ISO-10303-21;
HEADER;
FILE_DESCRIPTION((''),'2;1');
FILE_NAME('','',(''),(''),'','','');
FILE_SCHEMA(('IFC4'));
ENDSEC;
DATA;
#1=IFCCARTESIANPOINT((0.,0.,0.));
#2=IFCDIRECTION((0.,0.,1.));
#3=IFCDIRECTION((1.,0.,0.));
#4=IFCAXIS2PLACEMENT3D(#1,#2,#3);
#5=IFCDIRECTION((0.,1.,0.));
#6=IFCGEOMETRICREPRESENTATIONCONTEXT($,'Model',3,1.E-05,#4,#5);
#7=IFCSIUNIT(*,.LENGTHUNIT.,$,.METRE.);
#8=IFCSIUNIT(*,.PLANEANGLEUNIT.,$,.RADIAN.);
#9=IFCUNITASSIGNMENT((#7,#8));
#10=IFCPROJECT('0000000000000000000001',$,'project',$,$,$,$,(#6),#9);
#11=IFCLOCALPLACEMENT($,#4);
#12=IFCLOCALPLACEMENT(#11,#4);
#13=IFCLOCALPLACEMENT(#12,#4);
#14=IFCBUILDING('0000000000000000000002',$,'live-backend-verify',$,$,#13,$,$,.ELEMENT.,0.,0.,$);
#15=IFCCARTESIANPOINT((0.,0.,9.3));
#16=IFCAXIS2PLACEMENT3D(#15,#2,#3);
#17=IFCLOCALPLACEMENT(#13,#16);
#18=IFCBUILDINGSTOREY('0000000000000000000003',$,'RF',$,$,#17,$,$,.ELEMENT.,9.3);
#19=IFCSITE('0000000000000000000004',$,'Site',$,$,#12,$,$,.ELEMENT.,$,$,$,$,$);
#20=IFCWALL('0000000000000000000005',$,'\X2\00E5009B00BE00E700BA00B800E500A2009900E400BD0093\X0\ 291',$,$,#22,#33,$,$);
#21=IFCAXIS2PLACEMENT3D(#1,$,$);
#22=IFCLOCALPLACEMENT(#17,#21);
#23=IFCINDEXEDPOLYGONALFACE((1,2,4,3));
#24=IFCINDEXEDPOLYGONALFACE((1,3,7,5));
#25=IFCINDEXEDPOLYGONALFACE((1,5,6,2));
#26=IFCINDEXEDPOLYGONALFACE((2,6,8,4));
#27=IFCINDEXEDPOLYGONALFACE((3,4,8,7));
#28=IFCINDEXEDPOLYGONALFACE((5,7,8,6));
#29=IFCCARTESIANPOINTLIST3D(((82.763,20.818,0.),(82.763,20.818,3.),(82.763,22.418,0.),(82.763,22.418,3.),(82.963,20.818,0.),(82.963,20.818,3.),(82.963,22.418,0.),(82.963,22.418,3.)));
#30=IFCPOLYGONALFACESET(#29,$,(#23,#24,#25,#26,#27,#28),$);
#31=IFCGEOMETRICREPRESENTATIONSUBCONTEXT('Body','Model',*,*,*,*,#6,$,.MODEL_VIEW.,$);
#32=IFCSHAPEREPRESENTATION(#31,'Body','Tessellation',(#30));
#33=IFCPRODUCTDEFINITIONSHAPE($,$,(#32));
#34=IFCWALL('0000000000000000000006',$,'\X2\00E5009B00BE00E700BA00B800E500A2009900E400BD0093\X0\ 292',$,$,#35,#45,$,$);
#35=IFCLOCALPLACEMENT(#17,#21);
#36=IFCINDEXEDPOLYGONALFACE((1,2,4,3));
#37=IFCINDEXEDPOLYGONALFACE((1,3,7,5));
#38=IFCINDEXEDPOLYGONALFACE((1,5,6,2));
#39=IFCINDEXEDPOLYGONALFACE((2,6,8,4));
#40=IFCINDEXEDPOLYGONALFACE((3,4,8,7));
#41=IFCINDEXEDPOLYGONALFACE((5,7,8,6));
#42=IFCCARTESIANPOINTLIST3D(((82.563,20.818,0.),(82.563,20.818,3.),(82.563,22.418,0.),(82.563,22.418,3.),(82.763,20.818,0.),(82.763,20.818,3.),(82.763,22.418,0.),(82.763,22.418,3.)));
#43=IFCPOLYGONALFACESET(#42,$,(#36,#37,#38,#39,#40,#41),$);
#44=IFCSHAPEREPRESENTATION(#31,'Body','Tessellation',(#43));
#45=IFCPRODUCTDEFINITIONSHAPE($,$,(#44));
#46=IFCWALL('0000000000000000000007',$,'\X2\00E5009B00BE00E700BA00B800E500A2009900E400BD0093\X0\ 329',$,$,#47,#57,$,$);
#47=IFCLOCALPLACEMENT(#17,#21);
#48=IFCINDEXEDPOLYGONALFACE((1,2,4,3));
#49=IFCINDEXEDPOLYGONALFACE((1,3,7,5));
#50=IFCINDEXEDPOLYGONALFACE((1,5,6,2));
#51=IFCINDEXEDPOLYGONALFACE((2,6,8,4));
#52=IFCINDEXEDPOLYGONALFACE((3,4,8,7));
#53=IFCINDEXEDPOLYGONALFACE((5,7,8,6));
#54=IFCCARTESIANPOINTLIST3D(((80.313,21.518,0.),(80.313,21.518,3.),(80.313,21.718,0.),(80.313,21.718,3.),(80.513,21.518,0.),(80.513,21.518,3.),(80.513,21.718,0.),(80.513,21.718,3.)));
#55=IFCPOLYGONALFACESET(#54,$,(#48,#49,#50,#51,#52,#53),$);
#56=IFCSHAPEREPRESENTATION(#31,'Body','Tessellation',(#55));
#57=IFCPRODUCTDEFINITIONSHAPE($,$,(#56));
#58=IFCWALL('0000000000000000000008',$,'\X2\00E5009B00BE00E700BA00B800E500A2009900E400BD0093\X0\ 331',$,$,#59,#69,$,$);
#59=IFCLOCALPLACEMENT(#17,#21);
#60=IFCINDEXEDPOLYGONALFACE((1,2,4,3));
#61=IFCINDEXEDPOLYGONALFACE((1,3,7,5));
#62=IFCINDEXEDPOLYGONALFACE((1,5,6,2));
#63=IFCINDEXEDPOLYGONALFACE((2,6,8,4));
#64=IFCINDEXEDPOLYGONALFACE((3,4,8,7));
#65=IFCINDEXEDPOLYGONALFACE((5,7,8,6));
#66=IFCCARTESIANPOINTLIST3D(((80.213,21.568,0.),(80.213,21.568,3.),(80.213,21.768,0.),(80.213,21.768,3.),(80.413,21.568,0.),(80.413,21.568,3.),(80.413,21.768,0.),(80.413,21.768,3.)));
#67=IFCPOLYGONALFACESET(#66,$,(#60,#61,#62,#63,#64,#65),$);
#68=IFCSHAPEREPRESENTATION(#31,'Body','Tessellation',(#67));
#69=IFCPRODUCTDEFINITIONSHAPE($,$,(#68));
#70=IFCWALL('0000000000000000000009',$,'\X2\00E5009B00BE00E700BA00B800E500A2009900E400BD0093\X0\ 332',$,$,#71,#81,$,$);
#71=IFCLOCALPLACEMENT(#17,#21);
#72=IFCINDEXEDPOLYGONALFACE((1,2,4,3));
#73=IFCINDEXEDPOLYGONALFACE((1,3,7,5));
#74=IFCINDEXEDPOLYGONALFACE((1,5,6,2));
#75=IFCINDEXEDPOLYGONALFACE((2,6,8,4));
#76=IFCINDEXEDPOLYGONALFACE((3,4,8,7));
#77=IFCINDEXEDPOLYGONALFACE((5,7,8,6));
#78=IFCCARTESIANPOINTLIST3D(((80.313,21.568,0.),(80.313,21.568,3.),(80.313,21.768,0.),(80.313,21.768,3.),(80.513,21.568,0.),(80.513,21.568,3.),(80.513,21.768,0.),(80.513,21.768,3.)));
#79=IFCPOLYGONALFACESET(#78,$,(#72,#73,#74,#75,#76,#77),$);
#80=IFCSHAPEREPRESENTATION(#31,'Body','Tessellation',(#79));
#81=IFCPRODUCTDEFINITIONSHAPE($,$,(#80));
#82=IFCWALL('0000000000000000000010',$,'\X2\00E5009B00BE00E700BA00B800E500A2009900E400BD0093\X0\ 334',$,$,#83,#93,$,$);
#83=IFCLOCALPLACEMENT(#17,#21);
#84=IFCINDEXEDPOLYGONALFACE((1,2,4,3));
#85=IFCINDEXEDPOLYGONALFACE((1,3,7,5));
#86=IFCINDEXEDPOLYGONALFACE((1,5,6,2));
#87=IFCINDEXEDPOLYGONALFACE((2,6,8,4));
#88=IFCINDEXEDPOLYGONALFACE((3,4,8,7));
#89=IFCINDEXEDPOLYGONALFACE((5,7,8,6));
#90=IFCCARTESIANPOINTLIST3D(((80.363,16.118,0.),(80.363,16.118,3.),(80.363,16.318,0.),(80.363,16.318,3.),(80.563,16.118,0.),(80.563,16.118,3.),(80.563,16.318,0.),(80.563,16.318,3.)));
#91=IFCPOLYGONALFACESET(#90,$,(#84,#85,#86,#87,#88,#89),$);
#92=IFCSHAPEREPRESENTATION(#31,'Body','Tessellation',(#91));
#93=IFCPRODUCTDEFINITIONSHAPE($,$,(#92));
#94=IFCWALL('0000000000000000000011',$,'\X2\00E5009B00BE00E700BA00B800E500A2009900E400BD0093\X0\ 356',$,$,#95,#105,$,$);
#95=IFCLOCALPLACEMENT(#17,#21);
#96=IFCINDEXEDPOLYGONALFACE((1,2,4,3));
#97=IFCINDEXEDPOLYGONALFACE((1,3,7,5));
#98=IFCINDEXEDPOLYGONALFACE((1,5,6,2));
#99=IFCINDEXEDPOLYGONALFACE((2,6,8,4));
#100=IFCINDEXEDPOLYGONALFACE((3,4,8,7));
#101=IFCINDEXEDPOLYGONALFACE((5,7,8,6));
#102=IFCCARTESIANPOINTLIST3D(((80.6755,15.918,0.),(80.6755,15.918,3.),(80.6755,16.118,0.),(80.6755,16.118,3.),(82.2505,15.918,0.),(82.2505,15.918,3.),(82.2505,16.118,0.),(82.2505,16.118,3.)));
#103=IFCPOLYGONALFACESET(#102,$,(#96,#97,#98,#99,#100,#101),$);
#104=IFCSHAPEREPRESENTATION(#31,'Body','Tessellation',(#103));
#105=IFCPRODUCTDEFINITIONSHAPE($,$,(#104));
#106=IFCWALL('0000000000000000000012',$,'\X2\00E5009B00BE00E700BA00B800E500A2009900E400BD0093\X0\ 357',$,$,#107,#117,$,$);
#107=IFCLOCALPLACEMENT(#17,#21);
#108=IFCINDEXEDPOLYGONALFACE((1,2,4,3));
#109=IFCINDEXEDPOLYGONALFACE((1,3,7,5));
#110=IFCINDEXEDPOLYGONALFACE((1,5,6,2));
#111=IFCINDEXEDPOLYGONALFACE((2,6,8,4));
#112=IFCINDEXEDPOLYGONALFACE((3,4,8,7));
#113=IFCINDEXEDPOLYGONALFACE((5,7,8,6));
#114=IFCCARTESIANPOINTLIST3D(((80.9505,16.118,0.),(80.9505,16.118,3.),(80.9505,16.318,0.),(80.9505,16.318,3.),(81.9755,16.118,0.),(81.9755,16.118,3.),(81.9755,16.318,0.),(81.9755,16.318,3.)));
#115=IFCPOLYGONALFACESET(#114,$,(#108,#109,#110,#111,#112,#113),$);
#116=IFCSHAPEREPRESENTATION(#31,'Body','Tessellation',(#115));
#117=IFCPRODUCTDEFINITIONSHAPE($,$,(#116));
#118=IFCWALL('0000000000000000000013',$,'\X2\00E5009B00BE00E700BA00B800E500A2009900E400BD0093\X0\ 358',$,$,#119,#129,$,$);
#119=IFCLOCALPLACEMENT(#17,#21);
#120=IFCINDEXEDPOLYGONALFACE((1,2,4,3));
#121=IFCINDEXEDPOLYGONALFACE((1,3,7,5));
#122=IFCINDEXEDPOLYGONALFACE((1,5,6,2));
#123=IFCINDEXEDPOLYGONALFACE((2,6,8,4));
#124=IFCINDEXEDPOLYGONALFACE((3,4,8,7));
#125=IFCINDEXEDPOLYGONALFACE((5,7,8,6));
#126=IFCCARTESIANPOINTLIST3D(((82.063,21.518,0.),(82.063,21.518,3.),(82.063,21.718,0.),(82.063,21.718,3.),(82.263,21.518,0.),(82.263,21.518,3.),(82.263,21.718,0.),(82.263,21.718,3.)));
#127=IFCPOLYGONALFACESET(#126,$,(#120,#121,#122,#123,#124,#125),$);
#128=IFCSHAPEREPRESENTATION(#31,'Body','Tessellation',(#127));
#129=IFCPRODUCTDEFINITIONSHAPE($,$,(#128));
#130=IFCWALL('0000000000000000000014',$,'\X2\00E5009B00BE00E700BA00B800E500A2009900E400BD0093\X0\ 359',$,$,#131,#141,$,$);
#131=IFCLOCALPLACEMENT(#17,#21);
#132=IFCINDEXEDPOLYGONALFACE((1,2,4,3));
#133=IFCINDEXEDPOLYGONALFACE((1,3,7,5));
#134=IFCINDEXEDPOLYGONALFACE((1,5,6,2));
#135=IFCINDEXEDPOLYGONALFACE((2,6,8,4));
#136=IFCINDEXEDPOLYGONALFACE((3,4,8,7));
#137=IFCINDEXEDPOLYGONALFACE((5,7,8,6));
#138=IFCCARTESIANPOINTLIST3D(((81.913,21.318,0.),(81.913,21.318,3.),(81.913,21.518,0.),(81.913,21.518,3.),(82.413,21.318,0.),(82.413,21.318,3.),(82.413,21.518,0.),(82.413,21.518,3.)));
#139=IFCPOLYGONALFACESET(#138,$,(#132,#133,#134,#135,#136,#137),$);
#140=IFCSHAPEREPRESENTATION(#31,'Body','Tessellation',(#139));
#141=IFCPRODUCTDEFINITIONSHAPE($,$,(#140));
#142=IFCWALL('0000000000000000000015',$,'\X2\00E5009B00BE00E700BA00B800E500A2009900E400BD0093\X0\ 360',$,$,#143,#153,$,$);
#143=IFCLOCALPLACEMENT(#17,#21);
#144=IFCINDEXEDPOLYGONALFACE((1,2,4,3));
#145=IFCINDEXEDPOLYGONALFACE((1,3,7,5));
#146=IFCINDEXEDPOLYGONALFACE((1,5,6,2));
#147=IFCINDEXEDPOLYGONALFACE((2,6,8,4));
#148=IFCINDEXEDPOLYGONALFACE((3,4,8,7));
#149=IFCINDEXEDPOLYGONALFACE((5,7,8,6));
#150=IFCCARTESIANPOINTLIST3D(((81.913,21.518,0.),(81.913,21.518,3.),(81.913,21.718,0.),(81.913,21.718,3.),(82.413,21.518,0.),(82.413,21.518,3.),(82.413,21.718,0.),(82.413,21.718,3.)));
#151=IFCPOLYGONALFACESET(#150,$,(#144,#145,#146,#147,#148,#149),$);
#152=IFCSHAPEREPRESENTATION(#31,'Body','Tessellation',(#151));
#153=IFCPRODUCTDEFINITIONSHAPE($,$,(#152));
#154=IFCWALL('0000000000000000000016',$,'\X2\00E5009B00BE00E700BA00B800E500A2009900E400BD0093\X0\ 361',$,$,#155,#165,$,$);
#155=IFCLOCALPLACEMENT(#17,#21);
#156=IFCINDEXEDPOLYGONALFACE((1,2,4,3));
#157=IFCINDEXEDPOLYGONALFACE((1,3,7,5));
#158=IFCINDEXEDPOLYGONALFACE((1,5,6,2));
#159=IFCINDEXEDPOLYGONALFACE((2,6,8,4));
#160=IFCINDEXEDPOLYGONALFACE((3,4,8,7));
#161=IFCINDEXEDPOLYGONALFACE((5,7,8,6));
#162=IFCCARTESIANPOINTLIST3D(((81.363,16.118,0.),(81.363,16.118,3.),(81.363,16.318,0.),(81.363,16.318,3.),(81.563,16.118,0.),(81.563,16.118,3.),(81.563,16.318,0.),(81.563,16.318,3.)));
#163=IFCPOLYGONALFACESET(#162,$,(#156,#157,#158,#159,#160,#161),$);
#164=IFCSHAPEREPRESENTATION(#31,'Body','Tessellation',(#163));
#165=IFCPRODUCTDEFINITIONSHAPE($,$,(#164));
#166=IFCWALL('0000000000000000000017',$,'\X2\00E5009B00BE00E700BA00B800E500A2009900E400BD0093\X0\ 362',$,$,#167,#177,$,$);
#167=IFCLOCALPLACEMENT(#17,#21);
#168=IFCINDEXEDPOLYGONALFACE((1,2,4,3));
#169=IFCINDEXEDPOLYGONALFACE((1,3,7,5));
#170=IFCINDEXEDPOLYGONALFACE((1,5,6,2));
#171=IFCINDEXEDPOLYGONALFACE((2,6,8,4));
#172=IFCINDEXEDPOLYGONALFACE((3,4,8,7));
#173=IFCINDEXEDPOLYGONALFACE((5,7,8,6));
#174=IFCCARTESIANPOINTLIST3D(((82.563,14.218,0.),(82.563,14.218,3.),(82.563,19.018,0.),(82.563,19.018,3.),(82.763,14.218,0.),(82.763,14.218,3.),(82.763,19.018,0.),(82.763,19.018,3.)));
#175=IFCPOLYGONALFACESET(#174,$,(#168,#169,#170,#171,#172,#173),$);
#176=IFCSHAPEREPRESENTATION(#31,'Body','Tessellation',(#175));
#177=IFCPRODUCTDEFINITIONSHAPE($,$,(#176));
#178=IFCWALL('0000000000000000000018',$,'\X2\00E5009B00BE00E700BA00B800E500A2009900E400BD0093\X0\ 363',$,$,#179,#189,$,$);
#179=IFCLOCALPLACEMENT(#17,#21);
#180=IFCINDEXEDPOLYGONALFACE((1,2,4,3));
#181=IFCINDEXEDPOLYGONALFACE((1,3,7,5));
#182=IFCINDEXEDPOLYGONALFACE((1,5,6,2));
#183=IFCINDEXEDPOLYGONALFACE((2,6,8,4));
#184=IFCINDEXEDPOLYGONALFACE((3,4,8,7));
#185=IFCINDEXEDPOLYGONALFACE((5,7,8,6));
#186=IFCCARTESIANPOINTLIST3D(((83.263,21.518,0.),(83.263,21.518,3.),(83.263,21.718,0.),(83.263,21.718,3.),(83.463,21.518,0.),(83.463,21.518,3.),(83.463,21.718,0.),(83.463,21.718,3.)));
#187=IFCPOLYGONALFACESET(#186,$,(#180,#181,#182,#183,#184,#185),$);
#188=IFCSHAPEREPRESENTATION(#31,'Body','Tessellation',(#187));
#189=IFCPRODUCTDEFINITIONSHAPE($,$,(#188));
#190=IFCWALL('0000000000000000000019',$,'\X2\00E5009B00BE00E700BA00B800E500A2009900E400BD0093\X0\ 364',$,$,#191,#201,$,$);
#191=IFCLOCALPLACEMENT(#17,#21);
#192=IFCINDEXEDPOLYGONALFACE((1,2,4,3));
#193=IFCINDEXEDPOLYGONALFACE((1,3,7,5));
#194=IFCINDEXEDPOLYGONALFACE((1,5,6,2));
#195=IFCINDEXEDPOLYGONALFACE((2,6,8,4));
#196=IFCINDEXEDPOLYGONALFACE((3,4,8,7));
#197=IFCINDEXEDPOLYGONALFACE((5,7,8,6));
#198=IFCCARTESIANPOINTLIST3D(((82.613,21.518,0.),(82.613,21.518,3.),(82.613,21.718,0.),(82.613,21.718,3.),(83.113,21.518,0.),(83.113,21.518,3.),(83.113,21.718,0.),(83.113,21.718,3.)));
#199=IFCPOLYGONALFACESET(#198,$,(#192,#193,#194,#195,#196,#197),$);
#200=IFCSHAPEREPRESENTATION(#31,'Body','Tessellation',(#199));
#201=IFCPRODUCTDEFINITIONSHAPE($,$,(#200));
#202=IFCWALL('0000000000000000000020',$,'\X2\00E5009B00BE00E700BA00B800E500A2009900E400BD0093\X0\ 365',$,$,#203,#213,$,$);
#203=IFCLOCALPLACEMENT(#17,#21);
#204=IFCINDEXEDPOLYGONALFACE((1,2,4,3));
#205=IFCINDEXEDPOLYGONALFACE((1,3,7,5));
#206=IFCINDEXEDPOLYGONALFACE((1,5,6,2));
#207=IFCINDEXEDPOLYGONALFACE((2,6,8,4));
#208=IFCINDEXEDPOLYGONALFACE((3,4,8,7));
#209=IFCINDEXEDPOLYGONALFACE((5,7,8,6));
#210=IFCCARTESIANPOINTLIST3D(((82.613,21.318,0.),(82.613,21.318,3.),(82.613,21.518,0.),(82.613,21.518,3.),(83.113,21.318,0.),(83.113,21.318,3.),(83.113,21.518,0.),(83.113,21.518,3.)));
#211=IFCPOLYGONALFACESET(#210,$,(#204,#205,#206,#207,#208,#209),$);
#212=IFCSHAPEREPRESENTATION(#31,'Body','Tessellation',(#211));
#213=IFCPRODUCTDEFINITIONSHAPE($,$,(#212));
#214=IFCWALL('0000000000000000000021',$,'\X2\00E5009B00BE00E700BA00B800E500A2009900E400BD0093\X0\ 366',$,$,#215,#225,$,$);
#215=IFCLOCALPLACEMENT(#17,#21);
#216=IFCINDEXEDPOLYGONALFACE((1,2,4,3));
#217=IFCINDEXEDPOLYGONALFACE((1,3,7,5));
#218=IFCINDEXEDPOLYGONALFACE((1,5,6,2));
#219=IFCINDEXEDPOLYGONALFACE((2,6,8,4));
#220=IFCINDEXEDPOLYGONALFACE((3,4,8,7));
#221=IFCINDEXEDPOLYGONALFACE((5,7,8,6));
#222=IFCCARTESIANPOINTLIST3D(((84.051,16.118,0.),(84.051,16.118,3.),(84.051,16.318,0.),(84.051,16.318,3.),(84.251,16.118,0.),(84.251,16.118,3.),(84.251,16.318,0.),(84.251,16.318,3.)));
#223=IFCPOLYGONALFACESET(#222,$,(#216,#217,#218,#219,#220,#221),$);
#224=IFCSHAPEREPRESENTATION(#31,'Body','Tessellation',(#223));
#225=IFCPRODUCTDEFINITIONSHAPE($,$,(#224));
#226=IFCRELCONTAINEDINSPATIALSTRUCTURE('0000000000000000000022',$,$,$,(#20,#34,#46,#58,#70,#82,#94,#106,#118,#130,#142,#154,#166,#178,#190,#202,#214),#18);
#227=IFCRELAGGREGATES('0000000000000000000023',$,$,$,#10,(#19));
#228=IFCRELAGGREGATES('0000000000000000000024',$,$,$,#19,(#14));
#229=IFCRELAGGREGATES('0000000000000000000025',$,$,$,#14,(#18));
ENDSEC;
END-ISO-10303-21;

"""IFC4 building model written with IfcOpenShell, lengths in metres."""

from ifc_helpers import new_model, si_unit, direction, frame, frame_2d, origin_with_axes, place, context, subcontext, project, spatial, rectangle, extrude, element, save


model = new_model("IFC4")

# Units and contexts
model_context = context("Model", 3, precision=1e-05, world=origin_with_axes(), true_north=direction((0.0, 1.0, 0.0)))
body_context = subcontext(model_context, "Body", "Model", "MODEL_VIEW")
ifc_project = project(units=[si_unit("LENGTHUNIT", "METRE"), si_unit("PLANEANGLEUNIT", "RADIAN")], contexts=[model_context])

# Site, building, storey
placement = place(None, origin_with_axes())
site_placement = place(placement, origin_with_axes())
site = spatial("IfcSite", under=ifc_project, at=site_placement, Name="Site", CompositionType="ELEMENT")
building_placement = place(site_placement, origin_with_axes())
building = spatial("IfcBuilding", under=site, at=building_placement, Name="live-backend-verify", CompositionType="ELEMENT", ElevationOfRefHeight=0.0, ElevationOfTerrain=0.0)
storey_placement = place(building_placement, frame((0.0, 0.0, 9.3), z_axis=(0.0, 0.0, 1.0), x_axis=(1.0, 0.0, 0.0)))
storey = spatial("IfcBuildingStorey", under=building, at=storey_placement, Name="RF", CompositionType="ELEMENT", Elevation=9.3)

# Walls
for number, where, z_axis, x_axis, name in (
    (1, (82.863, 21.618, 0.0), (0.0, 0.0, 1.0), (0.0, 1.0, 0.0), "å\u009b¾çº¸å¢\u0099ä½\u0093 291"),
    (2, (82.663, 21.618, 0.0), (0.0, 0.0, 1.0), (0.0, 1.0, 0.0), "å\u009b¾çº¸å¢\u0099ä½\u0093 292"),
):
    element("IfcWall", number, at=place(storey_placement, frame(where, z_axis=z_axis, x_axis=x_axis)), inside=storey, Name=name, context=body_context, shape_type="SweptSolid", body=[
        extrude(rectangle(XDim=1.6, YDim=0.2, at=frame_2d((0.0, 0.0), x_axis=(1.0, 0.0, 0.0))), frame((0.0, 0.0, 0.0), z_axis=(0.0, 0.0, 1.0)), (0.0, 0.0, 1.0), 3.0),
    ])
for number, where, z_axis, x_axis, name in (
    (3, (80.413, 21.618, 0.0), (0.0, 0.0, 1.0), (0.0, -1.0, 0.0), "å\u009b¾çº¸å¢\u0099ä½\u0093 329"),
    (4, (80.313, 21.668, 0.0), (0.0, 0.0, 1.0), (1.0, 0.0, 0.0), "å\u009b¾çº¸å¢\u0099ä½\u0093 331"),
    (5, (80.413, 21.668, 0.0), (0.0, 0.0, 1.0), (0.0, -1.0, 0.0), "å\u009b¾çº¸å¢\u0099ä½\u0093 332"),
    (6, (80.463, 16.218, 0.0), (0.0, 0.0, 1.0), (0.0, -1.0, 0.0), "å\u009b¾çº¸å¢\u0099ä½\u0093 334"),
):
    element("IfcWall", number, at=place(storey_placement, frame(where, z_axis=z_axis, x_axis=x_axis)), inside=storey, Name=name, context=body_context, shape_type="SweptSolid", body=[
        extrude(rectangle(XDim=0.2, YDim=0.2, at=frame_2d((0.0, 0.0), x_axis=(1.0, 0.0, 0.0))), frame((0.0, 0.0, 0.0), z_axis=(0.0, 0.0, 1.0)), (0.0, 0.0, 1.0), 3.0),
    ])
wall_1_placement = place(storey_placement, frame((81.463, 16.018, 0.0), z_axis=(0.0, 0.0, 1.0), x_axis=(1.0, 0.0, 0.0)))
element("IfcWall", 7, at=wall_1_placement, inside=storey, Name="å\u009b¾çº¸å¢\u0099ä½\u0093 356", context=body_context, shape_type="SweptSolid", body=[
    extrude(rectangle(XDim=1.575, YDim=0.2, at=frame_2d((0.0, 0.0), x_axis=(1.0, 0.0, 0.0))), frame((0.0, 0.0, 0.0), z_axis=(0.0, 0.0, 1.0)), (0.0, 0.0, 1.0), 3.0),
])
wall_2_placement = place(storey_placement, frame((81.463, 16.218, 0.0), z_axis=(0.0, 0.0, 1.0), x_axis=(1.0, 0.0, 0.0)))
element("IfcWall", 8, at=wall_2_placement, inside=storey, Name="å\u009b¾çº¸å¢\u0099ä½\u0093 357", context=body_context, shape_type="SweptSolid", body=[
    extrude(rectangle(XDim=1.025, YDim=0.2, at=frame_2d((0.0, 0.0), x_axis=(1.0, 0.0, 0.0))), frame((0.0, 0.0, 0.0), z_axis=(0.0, 0.0, 1.0)), (0.0, 0.0, 1.0), 3.0),
])
wall_3_placement = place(storey_placement, frame((82.163, 21.618, 0.0), z_axis=(0.0, 0.0, 1.0), x_axis=(0.0, -1.0, 0.0)))
element("IfcWall", 9, at=wall_3_placement, inside=storey, Name="å\u009b¾çº¸å¢\u0099ä½\u0093 358", context=body_context, shape_type="SweptSolid", body=[
    extrude(rectangle(XDim=0.2, YDim=0.2, at=frame_2d((0.0, 0.0), x_axis=(1.0, 0.0, 0.0))), frame((0.0, 0.0, 0.0), z_axis=(0.0, 0.0, 1.0)), (0.0, 0.0, 1.0), 3.0),
])
for number, where, z_axis, x_axis, name in (
    (10, (82.163, 21.418, 0.0), (0.0, 0.0, 1.0), (1.0, 0.0, 0.0), "å\u009b¾çº¸å¢\u0099ä½\u0093 359"),
    (11, (82.163, 21.618, 0.0), (0.0, 0.0, 1.0), (1.0, 0.0, 0.0), "å\u009b¾çº¸å¢\u0099ä½\u0093 360"),
):
    element("IfcWall", number, at=place(storey_placement, frame(where, z_axis=z_axis, x_axis=x_axis)), inside=storey, Name=name, context=body_context, shape_type="SweptSolid", body=[
        extrude(rectangle(XDim=0.5, YDim=0.2, at=frame_2d((0.0, 0.0), x_axis=(1.0, 0.0, 0.0))), frame((0.0, 0.0, 0.0), z_axis=(0.0, 0.0, 1.0)), (0.0, 0.0, 1.0), 3.0),
    ])
wall_4_placement = place(storey_placement, frame((81.463, 16.218, 0.0), z_axis=(0.0, 0.0, 1.0), x_axis=(0.0, -1.0, 0.0)))
element("IfcWall", 12, at=wall_4_placement, inside=storey, Name="å\u009b¾çº¸å¢\u0099ä½\u0093 361", context=body_context, shape_type="SweptSolid", body=[
    extrude(rectangle(XDim=0.2, YDim=0.2, at=frame_2d((0.0, 0.0), x_axis=(1.0, 0.0, 0.0))), frame((0.0, 0.0, 0.0), z_axis=(0.0, 0.0, 1.0)), (0.0, 0.0, 1.0), 3.0),
])
wall_5_placement = place(storey_placement, frame((82.663, 16.618, 0.0), z_axis=(0.0, 0.0, 1.0), x_axis=(0.0, 1.0, 0.0)))
element("IfcWall", 13, at=wall_5_placement, inside=storey, Name="å\u009b¾çº¸å¢\u0099ä½\u0093 362", context=body_context, shape_type="SweptSolid", body=[
    extrude(rectangle(XDim=4.8, YDim=0.2, at=frame_2d((0.0, 0.0), x_axis=(1.0, 0.0, 0.0))), frame((0.0, 0.0, 0.0), z_axis=(0.0, 0.0, 1.0)), (0.0, 0.0, 1.0), 3.0),
])
wall_6_placement = place(storey_placement, frame((83.363, 21.618, 0.0), z_axis=(0.0, 0.0, 1.0), x_axis=(0.0, -1.0, 0.0)))
element("IfcWall", 14, at=wall_6_placement, inside=storey, Name="å\u009b¾çº¸å¢\u0099ä½\u0093 363", context=body_context, shape_type="SweptSolid", body=[
    extrude(rectangle(XDim=0.2, YDim=0.2, at=frame_2d((0.0, 0.0), x_axis=(1.0, 0.0, 0.0))), frame((0.0, 0.0, 0.0), z_axis=(0.0, 0.0, 1.0)), (0.0, 0.0, 1.0), 3.0),
])
for number, where, z_axis, x_axis, name in (
    (15, (82.863, 21.618, 0.0), (0.0, 0.0, 1.0), (1.0, 0.0, 0.0), "å\u009b¾çº¸å¢\u0099ä½\u0093 364"),
    (16, (82.863, 21.418, 0.0), (0.0, 0.0, 1.0), (1.0, 0.0, 0.0), "å\u009b¾çº¸å¢\u0099ä½\u0093 365"),
):
    element("IfcWall", number, at=place(storey_placement, frame(where, z_axis=z_axis, x_axis=x_axis)), inside=storey, Name=name, context=body_context, shape_type="SweptSolid", body=[
        extrude(rectangle(XDim=0.5, YDim=0.2, at=frame_2d((0.0, 0.0), x_axis=(1.0, 0.0, 0.0))), frame((0.0, 0.0, 0.0), z_axis=(0.0, 0.0, 1.0)), (0.0, 0.0, 1.0), 3.0),
    ])
wall_7_placement = place(storey_placement, frame((84.151, 16.218, 0.0), z_axis=(0.0, 0.0, 1.0), x_axis=(0.0, -1.0, 0.0)))
element("IfcWall", 17, at=wall_7_placement, inside=storey, Name="å\u009b¾çº¸å¢\u0099ä½\u0093 366", context=body_context, shape_type="SweptSolid", body=[
    extrude(rectangle(XDim=0.2, YDim=0.2, at=frame_2d((0.0, 0.0), x_axis=(1.0, 0.0, 0.0))), frame((0.0, 0.0, 0.0), z_axis=(0.0, 0.0, 1.0)), (0.0, 0.0, 1.0), 3.0),
])

save(model, "model.ifc")
